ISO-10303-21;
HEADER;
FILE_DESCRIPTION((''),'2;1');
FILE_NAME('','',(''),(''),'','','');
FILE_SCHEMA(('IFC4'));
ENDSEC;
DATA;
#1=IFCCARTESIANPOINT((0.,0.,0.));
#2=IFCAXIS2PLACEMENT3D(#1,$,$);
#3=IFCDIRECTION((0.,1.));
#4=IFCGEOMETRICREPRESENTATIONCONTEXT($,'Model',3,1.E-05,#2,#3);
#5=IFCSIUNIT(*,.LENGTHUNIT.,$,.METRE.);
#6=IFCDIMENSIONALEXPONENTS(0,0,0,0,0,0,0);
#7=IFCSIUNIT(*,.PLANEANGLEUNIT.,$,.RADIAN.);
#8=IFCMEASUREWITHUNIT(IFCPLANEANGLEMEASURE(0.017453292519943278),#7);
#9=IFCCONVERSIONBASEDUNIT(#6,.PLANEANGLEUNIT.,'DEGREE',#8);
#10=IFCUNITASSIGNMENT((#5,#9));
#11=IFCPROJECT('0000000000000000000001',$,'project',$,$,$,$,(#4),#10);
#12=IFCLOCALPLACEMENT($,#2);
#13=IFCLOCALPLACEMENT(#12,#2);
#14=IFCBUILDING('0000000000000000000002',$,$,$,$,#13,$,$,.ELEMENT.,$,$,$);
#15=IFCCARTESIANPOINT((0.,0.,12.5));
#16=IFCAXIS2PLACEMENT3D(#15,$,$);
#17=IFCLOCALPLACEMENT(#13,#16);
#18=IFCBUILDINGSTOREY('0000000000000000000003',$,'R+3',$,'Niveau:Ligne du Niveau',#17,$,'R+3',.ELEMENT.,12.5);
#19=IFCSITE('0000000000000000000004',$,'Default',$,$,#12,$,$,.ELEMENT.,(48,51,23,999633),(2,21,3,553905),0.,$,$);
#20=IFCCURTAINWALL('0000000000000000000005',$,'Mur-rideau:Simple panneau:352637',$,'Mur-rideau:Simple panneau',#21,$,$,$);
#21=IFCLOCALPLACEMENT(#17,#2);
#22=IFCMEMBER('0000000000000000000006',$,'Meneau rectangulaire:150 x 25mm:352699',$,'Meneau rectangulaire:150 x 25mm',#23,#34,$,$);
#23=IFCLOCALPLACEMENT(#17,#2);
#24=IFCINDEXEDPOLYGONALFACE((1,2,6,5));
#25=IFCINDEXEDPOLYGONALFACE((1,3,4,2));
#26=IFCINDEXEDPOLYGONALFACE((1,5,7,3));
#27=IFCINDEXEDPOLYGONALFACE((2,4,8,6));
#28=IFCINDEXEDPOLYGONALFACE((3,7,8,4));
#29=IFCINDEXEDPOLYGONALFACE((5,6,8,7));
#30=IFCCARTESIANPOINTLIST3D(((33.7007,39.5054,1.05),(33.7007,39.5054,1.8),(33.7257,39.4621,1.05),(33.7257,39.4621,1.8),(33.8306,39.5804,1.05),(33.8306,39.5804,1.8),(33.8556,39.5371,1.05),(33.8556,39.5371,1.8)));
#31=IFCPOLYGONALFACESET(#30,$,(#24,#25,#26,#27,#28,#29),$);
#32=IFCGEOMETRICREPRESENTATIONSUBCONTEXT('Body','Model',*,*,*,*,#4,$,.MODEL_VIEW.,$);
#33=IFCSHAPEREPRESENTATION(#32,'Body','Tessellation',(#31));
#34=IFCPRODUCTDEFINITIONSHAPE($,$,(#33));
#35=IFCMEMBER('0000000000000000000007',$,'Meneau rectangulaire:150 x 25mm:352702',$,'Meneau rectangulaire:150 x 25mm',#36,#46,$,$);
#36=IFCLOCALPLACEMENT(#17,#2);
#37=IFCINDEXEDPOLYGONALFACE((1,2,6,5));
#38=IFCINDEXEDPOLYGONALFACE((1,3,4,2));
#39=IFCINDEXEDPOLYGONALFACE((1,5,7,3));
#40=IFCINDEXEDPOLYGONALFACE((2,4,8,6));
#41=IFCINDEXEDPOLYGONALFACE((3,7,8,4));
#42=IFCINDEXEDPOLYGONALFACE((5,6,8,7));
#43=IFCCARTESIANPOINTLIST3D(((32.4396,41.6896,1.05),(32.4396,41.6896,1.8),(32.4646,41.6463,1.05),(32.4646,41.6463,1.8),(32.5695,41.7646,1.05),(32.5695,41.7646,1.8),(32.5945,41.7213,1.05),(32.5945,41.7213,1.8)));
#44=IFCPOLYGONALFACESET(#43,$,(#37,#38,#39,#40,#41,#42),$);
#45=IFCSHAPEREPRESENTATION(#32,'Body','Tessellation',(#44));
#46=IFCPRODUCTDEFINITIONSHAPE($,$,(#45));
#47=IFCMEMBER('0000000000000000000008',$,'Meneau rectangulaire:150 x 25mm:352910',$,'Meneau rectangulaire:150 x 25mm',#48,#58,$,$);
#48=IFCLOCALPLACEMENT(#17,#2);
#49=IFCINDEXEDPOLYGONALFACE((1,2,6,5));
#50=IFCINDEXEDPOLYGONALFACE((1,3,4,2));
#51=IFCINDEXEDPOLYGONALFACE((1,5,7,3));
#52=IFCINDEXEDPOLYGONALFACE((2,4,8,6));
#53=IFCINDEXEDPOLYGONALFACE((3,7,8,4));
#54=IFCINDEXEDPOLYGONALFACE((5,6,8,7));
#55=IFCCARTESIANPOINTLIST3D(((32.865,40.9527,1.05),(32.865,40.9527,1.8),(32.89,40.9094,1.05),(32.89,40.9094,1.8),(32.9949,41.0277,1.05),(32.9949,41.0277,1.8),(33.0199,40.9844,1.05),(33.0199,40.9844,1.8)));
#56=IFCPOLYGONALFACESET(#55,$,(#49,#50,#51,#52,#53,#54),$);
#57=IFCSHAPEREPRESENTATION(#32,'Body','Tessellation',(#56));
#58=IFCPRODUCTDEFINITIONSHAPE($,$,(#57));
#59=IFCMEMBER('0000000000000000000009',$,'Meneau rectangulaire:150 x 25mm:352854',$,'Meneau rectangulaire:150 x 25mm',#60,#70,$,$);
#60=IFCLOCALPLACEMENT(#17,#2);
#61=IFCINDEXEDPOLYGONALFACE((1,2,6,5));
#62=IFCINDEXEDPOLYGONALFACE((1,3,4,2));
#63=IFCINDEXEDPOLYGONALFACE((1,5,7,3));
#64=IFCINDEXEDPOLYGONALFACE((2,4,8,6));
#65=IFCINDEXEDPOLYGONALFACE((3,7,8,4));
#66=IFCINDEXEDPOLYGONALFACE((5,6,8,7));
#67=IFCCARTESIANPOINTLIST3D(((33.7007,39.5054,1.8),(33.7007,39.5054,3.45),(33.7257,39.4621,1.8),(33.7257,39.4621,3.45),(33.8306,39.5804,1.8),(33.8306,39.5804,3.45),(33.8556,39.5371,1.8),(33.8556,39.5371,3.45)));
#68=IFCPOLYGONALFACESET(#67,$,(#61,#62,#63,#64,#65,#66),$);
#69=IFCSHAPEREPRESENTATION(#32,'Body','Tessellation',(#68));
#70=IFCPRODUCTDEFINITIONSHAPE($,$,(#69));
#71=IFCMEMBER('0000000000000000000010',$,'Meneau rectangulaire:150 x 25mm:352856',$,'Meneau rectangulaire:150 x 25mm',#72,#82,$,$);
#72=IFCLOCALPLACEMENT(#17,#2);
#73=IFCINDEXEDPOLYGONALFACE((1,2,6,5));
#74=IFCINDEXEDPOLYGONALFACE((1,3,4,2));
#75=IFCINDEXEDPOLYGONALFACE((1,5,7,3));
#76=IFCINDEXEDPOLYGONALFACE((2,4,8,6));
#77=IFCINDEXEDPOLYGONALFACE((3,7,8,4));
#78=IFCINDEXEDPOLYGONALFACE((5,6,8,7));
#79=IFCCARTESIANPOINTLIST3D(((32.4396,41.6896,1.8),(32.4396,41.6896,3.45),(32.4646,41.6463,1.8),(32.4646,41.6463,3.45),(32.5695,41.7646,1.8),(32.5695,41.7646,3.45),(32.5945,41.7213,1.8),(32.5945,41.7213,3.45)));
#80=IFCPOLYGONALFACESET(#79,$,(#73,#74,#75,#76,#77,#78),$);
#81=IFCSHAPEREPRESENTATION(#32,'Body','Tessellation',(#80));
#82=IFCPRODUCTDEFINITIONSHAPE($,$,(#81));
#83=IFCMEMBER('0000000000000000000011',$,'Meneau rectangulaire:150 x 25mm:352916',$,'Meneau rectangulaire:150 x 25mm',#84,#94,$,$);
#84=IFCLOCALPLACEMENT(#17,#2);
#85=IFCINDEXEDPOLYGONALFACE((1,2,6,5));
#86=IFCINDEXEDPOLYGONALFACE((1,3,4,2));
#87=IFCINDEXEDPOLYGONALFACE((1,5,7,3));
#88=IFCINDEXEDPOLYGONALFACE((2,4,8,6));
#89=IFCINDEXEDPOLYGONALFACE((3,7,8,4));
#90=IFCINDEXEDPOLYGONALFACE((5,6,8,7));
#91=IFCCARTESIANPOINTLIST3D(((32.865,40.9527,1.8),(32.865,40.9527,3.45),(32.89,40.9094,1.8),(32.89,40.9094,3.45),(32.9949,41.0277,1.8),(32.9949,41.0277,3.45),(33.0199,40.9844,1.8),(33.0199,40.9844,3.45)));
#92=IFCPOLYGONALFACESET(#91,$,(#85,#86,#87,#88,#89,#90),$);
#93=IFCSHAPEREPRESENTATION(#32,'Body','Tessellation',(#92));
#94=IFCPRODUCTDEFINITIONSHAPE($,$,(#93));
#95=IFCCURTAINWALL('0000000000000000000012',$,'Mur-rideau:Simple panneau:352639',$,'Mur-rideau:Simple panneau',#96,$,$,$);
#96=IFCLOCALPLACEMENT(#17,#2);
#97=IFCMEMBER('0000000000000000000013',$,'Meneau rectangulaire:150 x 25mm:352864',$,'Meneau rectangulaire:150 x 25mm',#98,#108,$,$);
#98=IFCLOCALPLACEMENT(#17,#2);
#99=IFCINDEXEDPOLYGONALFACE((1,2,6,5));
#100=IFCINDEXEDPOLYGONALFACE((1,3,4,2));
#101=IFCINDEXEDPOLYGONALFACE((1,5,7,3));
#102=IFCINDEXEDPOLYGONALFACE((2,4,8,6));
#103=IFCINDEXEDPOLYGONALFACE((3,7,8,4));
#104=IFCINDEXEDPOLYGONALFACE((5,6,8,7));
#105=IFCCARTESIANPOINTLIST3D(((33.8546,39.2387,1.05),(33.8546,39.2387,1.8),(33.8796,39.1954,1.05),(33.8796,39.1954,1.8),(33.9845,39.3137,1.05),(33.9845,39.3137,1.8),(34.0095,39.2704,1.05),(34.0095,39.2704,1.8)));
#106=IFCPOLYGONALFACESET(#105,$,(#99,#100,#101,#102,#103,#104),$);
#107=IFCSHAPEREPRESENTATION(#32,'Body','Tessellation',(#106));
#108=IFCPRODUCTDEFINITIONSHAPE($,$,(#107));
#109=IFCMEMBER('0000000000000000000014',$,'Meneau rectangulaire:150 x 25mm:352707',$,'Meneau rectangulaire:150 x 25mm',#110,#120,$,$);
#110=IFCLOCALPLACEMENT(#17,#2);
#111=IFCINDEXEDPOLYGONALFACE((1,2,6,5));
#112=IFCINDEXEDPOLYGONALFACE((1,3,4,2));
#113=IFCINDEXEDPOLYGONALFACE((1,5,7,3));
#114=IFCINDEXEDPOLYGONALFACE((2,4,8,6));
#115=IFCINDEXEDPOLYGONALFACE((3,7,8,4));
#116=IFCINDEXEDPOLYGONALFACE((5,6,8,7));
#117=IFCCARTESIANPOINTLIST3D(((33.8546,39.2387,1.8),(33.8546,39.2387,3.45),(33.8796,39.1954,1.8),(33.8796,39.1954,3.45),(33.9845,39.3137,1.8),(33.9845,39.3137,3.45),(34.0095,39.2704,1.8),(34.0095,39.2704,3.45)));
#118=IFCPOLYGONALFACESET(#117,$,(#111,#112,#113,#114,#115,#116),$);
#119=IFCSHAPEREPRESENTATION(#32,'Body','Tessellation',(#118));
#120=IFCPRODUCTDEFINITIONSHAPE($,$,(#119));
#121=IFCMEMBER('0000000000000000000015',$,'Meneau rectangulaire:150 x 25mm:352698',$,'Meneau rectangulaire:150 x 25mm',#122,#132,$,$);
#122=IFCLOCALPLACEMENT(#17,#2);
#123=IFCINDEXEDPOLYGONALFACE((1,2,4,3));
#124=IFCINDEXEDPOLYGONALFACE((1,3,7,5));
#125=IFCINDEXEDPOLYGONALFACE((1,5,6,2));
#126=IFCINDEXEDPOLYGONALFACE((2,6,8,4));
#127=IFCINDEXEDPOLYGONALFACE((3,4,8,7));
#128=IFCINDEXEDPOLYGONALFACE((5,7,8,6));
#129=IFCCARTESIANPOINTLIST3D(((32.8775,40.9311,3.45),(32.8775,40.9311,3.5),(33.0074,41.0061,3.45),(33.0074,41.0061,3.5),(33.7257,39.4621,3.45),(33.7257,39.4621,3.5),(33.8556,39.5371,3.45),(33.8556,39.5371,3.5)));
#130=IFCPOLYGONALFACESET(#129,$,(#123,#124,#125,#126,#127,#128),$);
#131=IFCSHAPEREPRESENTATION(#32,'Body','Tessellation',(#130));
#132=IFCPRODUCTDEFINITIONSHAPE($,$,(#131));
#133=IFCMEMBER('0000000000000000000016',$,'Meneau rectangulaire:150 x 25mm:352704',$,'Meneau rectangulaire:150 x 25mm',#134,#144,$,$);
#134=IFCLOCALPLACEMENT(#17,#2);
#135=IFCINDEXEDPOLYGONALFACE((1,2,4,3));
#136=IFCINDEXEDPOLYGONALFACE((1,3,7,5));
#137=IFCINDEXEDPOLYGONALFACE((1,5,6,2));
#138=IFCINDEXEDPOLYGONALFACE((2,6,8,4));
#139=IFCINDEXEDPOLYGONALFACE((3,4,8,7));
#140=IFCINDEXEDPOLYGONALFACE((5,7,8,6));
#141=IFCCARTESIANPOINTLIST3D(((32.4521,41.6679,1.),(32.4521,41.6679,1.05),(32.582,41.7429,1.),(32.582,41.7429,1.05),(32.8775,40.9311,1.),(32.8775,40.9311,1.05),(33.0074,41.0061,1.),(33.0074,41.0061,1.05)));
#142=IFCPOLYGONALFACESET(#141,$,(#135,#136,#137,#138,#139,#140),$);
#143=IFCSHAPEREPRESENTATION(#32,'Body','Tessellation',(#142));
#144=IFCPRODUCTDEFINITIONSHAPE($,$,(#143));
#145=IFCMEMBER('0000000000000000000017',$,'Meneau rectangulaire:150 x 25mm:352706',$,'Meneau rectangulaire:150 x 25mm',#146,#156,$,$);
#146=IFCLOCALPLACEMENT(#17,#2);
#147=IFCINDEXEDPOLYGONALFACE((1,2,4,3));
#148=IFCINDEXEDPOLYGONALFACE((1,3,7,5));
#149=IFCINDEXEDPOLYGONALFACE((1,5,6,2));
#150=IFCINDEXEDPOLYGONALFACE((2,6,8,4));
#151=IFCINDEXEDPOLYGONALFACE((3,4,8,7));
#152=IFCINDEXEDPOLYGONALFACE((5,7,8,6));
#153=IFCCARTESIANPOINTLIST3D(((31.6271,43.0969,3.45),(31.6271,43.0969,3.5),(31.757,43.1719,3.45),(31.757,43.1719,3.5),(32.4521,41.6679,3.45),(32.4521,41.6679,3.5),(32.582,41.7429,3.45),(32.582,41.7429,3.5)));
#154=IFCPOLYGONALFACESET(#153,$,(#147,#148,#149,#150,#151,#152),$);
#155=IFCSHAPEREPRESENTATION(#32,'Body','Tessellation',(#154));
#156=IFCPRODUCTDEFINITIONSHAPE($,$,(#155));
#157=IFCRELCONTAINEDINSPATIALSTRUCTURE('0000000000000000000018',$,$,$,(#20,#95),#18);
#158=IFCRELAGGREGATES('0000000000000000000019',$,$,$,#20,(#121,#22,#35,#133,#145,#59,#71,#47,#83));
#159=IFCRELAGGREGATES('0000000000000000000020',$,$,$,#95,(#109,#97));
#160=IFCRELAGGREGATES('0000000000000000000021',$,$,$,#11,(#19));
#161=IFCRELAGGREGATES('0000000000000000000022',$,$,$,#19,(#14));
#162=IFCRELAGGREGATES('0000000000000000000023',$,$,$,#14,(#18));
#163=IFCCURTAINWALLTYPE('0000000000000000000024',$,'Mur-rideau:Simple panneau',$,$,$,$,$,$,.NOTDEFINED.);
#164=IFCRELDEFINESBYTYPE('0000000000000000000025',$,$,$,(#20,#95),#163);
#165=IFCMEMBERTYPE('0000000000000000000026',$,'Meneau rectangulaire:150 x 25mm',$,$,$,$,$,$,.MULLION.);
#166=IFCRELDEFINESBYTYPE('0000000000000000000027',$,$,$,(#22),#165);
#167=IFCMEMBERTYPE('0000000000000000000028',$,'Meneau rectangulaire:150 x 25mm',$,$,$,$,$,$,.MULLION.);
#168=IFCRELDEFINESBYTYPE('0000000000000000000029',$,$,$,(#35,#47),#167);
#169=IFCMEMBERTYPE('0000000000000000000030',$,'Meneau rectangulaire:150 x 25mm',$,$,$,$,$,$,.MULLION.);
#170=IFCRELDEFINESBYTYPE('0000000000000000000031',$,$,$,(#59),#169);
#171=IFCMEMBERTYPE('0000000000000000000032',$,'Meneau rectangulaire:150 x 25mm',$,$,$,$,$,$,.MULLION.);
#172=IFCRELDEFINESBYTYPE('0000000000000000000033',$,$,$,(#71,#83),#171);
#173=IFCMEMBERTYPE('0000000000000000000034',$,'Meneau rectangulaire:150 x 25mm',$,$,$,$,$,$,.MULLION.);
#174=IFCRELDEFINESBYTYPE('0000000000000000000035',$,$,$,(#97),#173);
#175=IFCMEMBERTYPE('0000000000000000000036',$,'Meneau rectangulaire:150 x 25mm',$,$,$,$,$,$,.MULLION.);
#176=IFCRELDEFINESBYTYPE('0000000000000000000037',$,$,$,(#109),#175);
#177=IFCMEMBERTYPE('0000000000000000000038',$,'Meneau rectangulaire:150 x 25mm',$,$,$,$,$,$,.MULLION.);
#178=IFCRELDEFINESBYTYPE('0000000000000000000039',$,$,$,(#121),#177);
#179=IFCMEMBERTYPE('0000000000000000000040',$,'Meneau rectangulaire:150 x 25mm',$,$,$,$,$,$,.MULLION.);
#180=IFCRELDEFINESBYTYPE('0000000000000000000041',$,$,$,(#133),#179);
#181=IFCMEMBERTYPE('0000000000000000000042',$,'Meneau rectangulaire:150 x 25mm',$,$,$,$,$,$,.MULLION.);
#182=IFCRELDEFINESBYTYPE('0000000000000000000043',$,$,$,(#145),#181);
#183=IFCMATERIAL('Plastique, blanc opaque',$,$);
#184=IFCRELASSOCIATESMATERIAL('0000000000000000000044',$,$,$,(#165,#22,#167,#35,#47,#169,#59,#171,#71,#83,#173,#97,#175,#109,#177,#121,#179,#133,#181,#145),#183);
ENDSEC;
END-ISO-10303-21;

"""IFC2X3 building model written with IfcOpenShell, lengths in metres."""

from ifc_helpers import new_model, entity, si_unit, converted_unit, direction, frame, origin, origin_2d_with_axis, place, context, subcontext, project, spatial, rectangle, extrude, source, transform, mapped, material, type_object, type_shapes, element, aggregate, save


model = new_model("IFC2X3")

# Units and contexts
model_context = context("Model", 3, precision=1e-05, world=origin(), true_north=direction((0.0, 1.0)))
body_context = subcontext(model_context, "Body", "Model", "MODEL_VIEW")
ifc_project = project(units=[si_unit("LENGTHUNIT", "METRE"), converted_unit("PLANEANGLEUNIT", "DEGREE", entity("IfcPlaneAngleMeasure", 0.017453292519943278), si_unit("PLANEANGLEUNIT", "RADIAN"), dimensions=[0, 0, 0, 0, 0, 0, 0])], contexts=[model_context])

# Site, building, storey
site_placement = place(None, origin())
site = spatial("IfcSite", under=ifc_project, at=site_placement, Name="Default", CompositionType="ELEMENT", RefLatitude=(48, 51, 23, 999633), RefLongitude=(2, 21, 3, 553905), RefElevation=0.0)
building_placement = place(site_placement, origin())
building = spatial("IfcBuilding", under=site, at=building_placement, CompositionType="ELEMENT")
storey_placement = place(building_placement, frame((0.0, 0.0, 12.5)))
storey = spatial("IfcBuildingStorey", under=building, at=storey_placement, Name="R+3", ObjectType="Niveau:Ligne du Niveau", LongName="R+3", CompositionType="ELEMENT", Elevation=12.5)

# Curtain walls, members
curtain_wall_type = type_object("IfcCurtainWallType", Name="Mur-rideau:Simple panneau", PredefinedType="NOTDEFINED")
curtain_wall_1_placement = place(storey_placement, frame((0.0, 0.0, -12.5)))
curtain_wall_1 = element("IfcCurtainWall", 1, at=curtain_wall_1_placement, inside=storey, type_object=curtain_wall_type, Name="Mur-rideau:Simple panneau:352637", ObjectType="Mur-rideau:Simple panneau")
ifc_material_1 = material(Name="Plastique, blanc opaque")
member_type_1 = type_object("IfcMemberType", Name="Meneau rectangulaire:150 x 25mm", PredefinedType="MULLION", material=ifc_material_1)
shared_shape_1 = source(origin(), body_context, "Body", "SweptSolid", [
    extrude(rectangle(XDim=0.05, YDim=0.15, at=origin_2d_with_axis()), frame((-0.025, 0.0, -0.75), z_axis=(0.0, 0.0, 1.0), x_axis=(-1.0, 0.0, 0.0)), (0.0, 0.0, 1.0), 0.75),
])
type_shapes(member_type_1, [shared_shape_1])
member_1_placement = place(curtain_wall_1_placement, frame((33.7906, 39.4996, 13.55), z_axis=(0.0, 0.0, -1.0), x_axis=(0.5, -0.866025, 0.0)))
member_1 = element("IfcMember", 2, at=member_1_placement, type_object=member_type_1, material=ifc_material_1, Name="Meneau rectangulaire:150 x 25mm:352699", ObjectType="Meneau rectangulaire:150 x 25mm", context=body_context, shape_type="MappedRepresentation", body=[
    mapped(shared_shape_1, transform((0.0, 0.0, 0.0), scale=1.0)),
])
member_type_2 = type_object("IfcMemberType", Name="Meneau rectangulaire:150 x 25mm", PredefinedType="MULLION", material=ifc_material_1)
shared_shape_2 = source(origin(), body_context, "Body", "SweptSolid", [
    extrude(rectangle(XDim=0.05, YDim=0.15, at=origin_2d_with_axis()), frame((0.0, 0.0, -0.75), z_axis=(0.0, 0.0, 1.0), x_axis=(-1.0, 0.0, 0.0)), (0.0, 0.0, 1.0), 0.75),
])
type_shapes(member_type_2, [shared_shape_2])
member_2_placement = place(curtain_wall_1_placement, frame((32.5171, 41.7054, 13.55), z_axis=(0.0, 0.0, -1.0), x_axis=(0.5, -0.866025, 0.0)))
member_2 = element("IfcMember", 3, at=member_2_placement, type_object=member_type_2, material=ifc_material_1, Name="Meneau rectangulaire:150 x 25mm:352702", ObjectType="Meneau rectangulaire:150 x 25mm", context=body_context, shape_type="MappedRepresentation", body=[
    mapped(shared_shape_2, transform((0.0, 0.0, 0.0), scale=1.0)),
])
member_3_placement = place(curtain_wall_1_placement, frame((32.9425, 40.9686, 13.55), z_axis=(0.0, 0.0, -1.0), x_axis=(0.5, -0.866025, 0.0)))
member_3 = element("IfcMember", 4, at=member_3_placement, type_object=member_type_2, material=ifc_material_1, Name="Meneau rectangulaire:150 x 25mm:352910", ObjectType="Meneau rectangulaire:150 x 25mm", context=body_context, shape_type="MappedRepresentation", body=[
    mapped(shared_shape_2, transform((0.0, 0.0, 0.0), scale=1.0)),
])
member_type_3 = type_object("IfcMemberType", Name="Meneau rectangulaire:150 x 25mm", PredefinedType="MULLION", material=ifc_material_1)
shared_shape_3 = source(origin(), body_context, "Body", "SweptSolid", [
    extrude(rectangle(XDim=0.05, YDim=0.15, at=origin_2d_with_axis()), frame((-0.025, 0.0, -1.65), z_axis=(0.0, 0.0, 1.0), x_axis=(-1.0, 0.0, 0.0)), (0.0, 0.0, 1.0), 1.65),
])
type_shapes(member_type_3, [shared_shape_3])
member_4_placement = place(curtain_wall_1_placement, frame((33.7906, 39.4996, 14.3), z_axis=(0.0, 0.0, -1.0), x_axis=(0.5, -0.866025, 0.0)))
member_4 = element("IfcMember", 5, at=member_4_placement, type_object=member_type_3, material=ifc_material_1, Name="Meneau rectangulaire:150 x 25mm:352854", ObjectType="Meneau rectangulaire:150 x 25mm", context=body_context, shape_type="MappedRepresentation", body=[
    mapped(shared_shape_3, transform((0.0, 0.0, 0.0), scale=1.0)),
])
member_type_4 = type_object("IfcMemberType", Name="Meneau rectangulaire:150 x 25mm", PredefinedType="MULLION", material=ifc_material_1)
shared_shape_4 = source(origin(), body_context, "Body", "SweptSolid", [
    extrude(rectangle(XDim=0.05, YDim=0.15, at=origin_2d_with_axis()), frame((0.0, 0.0, -1.65), z_axis=(0.0, 0.0, 1.0), x_axis=(-1.0, 0.0, 0.0)), (0.0, 0.0, 1.0), 1.65),
])
type_shapes(member_type_4, [shared_shape_4])
member_5_placement = place(curtain_wall_1_placement, frame((32.5171, 41.7054, 14.3), z_axis=(0.0, 0.0, -1.0), x_axis=(0.5, -0.866025, 0.0)))
member_5 = element("IfcMember", 6, at=member_5_placement, type_object=member_type_4, material=ifc_material_1, Name="Meneau rectangulaire:150 x 25mm:352856", ObjectType="Meneau rectangulaire:150 x 25mm", context=body_context, shape_type="MappedRepresentation", body=[
    mapped(shared_shape_4, transform((0.0, 0.0, 0.0), scale=1.0)),
])
member_6_placement = place(curtain_wall_1_placement, frame((32.9425, 40.9686, 14.3), z_axis=(0.0, 0.0, -1.0), x_axis=(0.5, -0.866025, 0.0)))
member_6 = element("IfcMember", 7, at=member_6_placement, type_object=member_type_4, material=ifc_material_1, Name="Meneau rectangulaire:150 x 25mm:352916", ObjectType="Meneau rectangulaire:150 x 25mm", context=body_context, shape_type="MappedRepresentation", body=[
    mapped(shared_shape_4, transform((0.0, 0.0, 0.0), scale=1.0)),
])
curtain_wall_2_placement = place(storey_placement, frame((0.0, 0.0, -12.5)))
curtain_wall_2 = element("IfcCurtainWall", 8, at=curtain_wall_2_placement, inside=storey, type_object=curtain_wall_type, Name="Mur-rideau:Simple panneau:352639", ObjectType="Mur-rideau:Simple panneau")
member_type_5 = type_object("IfcMemberType", Name="Meneau rectangulaire:150 x 25mm", PredefinedType="MULLION", material=ifc_material_1)
shared_shape_5 = source(origin(), body_context, "Body", "SweptSolid", [
    extrude(rectangle(XDim=0.05, YDim=0.15, at=origin_2d_with_axis()), frame((-0.025, 0.0, -0.75), z_axis=(0.0, 0.0, 1.0), x_axis=(-1.0, 0.0, 0.0)), (0.0, 0.0, 1.0), 0.75),
])
type_shapes(member_type_5, [shared_shape_5])
member_7_placement = place(curtain_wall_2_placement, frame((33.9196, 39.2762, 14.3), z_axis=(0.0, 0.0, 1.0), x_axis=(-0.5, 0.866025, 0.0)))
member_7 = element("IfcMember", 9, at=member_7_placement, type_object=member_type_5, material=ifc_material_1, Name="Meneau rectangulaire:150 x 25mm:352864", ObjectType="Meneau rectangulaire:150 x 25mm", context=body_context, shape_type="MappedRepresentation", body=[
    mapped(shared_shape_5, transform((0.0, 0.0, 0.0), scale=1.0)),
])
member_type_6 = type_object("IfcMemberType", Name="Meneau rectangulaire:150 x 25mm", PredefinedType="MULLION", material=ifc_material_1)
shared_shape_6 = source(origin(), body_context, "Body", "SweptSolid", [
    extrude(rectangle(XDim=0.05, YDim=0.15, at=origin_2d_with_axis()), frame((-0.025, 0.0, -1.65), z_axis=(0.0, 0.0, 1.0), x_axis=(-1.0, 0.0, 0.0)), (0.0, 0.0, 1.0), 1.65),
])
type_shapes(member_type_6, [shared_shape_6])
member_8_placement = place(curtain_wall_2_placement, frame((33.9196, 39.2762, 15.95), z_axis=(0.0, 0.0, 1.0), x_axis=(-0.5, 0.866025, 0.0)))
member_8 = element("IfcMember", 10, at=member_8_placement, type_object=member_type_6, material=ifc_material_1, Name="Meneau rectangulaire:150 x 25mm:352707", ObjectType="Meneau rectangulaire:150 x 25mm", context=body_context, shape_type="MappedRepresentation", body=[
    mapped(shared_shape_6, transform((0.0, 0.0, 0.0), scale=1.0)),
])

# Members
member_type_7 = type_object("IfcMemberType", Name="Meneau rectangulaire:150 x 25mm", PredefinedType="MULLION", material=ifc_material_1)
shared_shape_7 = source(origin(), body_context, "Body", "SweptSolid", [
    extrude(rectangle(XDim=0.05, YDim=0.15, at=origin_2d_with_axis()), frame((-0.025, 0.0, -1.6963), z_axis=(0.0, 0.0, 1.0), x_axis=(-1.0, 0.0, 0.0)), (0.0, 0.0, 1.0), 1.6963),
])
type_shapes(member_type_7, [shared_shape_7])
member_9_placement = place(curtain_wall_1_placement, frame((33.7906, 39.4996, 16.0), z_axis=(0.5, -0.866025, 0.0), x_axis=(0.0, 0.0, 1.0)))
member_9 = element("IfcMember", 11, at=member_9_placement, type_object=member_type_7, material=ifc_material_1, Name="Meneau rectangulaire:150 x 25mm:352698", ObjectType="Meneau rectangulaire:150 x 25mm", context=body_context, shape_type="MappedRepresentation", body=[
    mapped(shared_shape_7, transform((0.0, 0.0, 0.0), scale=1.0)),
])
member_type_8 = type_object("IfcMemberType", Name="Meneau rectangulaire:150 x 25mm", PredefinedType="MULLION", material=ifc_material_1)
shared_shape_8 = source(origin(), body_context, "Body", "SweptSolid", [
    extrude(rectangle(XDim=0.05, YDim=0.15, at=origin_2d_with_axis()), frame((-0.025, 0.0, -0.8508), z_axis=(0.0, 0.0, 1.0), x_axis=(-1.0, 0.0, 0.0)), (0.0, 0.0, 1.0), 0.8508),
])
type_shapes(member_type_8, [shared_shape_8])
member_10_placement = place(curtain_wall_1_placement, frame((32.5171, 41.7054, 13.5), z_axis=(-0.5, 0.866025, 0.0), x_axis=(0.0, 0.0, -1.0)))
member_10 = element("IfcMember", 12, at=member_10_placement, type_object=member_type_8, material=ifc_material_1, Name="Meneau rectangulaire:150 x 25mm:352704", ObjectType="Meneau rectangulaire:150 x 25mm", context=body_context, shape_type="MappedRepresentation", body=[
    mapped(shared_shape_8, transform((0.0, 0.0, 0.0), scale=1.0)),
])
member_type_9 = type_object("IfcMemberType", Name="Meneau rectangulaire:150 x 25mm", PredefinedType="MULLION", material=ifc_material_1)
shared_shape_9 = source(origin(), body_context, "Body", "SweptSolid", [
    extrude(rectangle(XDim=0.05, YDim=0.15, at=origin_2d_with_axis()), frame((-0.025, 0.0, -1.65), z_axis=(0.0, 0.0, 1.0), x_axis=(-1.0, 0.0, 0.0)), (0.0, 0.0, 1.0), 1.65),
])
type_shapes(member_type_9, [shared_shape_9])
member_11_placement = place(curtain_wall_1_placement, frame((32.5171, 41.7054, 16.0), z_axis=(0.5, -0.866025, 0.0), x_axis=(0.0, 0.0, 1.0)))
member_11 = element("IfcMember", 13, at=member_11_placement, type_object=member_type_9, material=ifc_material_1, Name="Meneau rectangulaire:150 x 25mm:352706", ObjectType="Meneau rectangulaire:150 x 25mm", context=body_context, shape_type="MappedRepresentation", body=[
    mapped(shared_shape_9, transform((0.0, 0.0, 0.0), scale=1.0)),
])

aggregate(curtain_wall_1, [member_9, member_1, member_2, member_10, member_11, member_4, member_5, member_3, member_6])
aggregate(curtain_wall_2, [member_8, member_7])

save(model, "model.ifc")
